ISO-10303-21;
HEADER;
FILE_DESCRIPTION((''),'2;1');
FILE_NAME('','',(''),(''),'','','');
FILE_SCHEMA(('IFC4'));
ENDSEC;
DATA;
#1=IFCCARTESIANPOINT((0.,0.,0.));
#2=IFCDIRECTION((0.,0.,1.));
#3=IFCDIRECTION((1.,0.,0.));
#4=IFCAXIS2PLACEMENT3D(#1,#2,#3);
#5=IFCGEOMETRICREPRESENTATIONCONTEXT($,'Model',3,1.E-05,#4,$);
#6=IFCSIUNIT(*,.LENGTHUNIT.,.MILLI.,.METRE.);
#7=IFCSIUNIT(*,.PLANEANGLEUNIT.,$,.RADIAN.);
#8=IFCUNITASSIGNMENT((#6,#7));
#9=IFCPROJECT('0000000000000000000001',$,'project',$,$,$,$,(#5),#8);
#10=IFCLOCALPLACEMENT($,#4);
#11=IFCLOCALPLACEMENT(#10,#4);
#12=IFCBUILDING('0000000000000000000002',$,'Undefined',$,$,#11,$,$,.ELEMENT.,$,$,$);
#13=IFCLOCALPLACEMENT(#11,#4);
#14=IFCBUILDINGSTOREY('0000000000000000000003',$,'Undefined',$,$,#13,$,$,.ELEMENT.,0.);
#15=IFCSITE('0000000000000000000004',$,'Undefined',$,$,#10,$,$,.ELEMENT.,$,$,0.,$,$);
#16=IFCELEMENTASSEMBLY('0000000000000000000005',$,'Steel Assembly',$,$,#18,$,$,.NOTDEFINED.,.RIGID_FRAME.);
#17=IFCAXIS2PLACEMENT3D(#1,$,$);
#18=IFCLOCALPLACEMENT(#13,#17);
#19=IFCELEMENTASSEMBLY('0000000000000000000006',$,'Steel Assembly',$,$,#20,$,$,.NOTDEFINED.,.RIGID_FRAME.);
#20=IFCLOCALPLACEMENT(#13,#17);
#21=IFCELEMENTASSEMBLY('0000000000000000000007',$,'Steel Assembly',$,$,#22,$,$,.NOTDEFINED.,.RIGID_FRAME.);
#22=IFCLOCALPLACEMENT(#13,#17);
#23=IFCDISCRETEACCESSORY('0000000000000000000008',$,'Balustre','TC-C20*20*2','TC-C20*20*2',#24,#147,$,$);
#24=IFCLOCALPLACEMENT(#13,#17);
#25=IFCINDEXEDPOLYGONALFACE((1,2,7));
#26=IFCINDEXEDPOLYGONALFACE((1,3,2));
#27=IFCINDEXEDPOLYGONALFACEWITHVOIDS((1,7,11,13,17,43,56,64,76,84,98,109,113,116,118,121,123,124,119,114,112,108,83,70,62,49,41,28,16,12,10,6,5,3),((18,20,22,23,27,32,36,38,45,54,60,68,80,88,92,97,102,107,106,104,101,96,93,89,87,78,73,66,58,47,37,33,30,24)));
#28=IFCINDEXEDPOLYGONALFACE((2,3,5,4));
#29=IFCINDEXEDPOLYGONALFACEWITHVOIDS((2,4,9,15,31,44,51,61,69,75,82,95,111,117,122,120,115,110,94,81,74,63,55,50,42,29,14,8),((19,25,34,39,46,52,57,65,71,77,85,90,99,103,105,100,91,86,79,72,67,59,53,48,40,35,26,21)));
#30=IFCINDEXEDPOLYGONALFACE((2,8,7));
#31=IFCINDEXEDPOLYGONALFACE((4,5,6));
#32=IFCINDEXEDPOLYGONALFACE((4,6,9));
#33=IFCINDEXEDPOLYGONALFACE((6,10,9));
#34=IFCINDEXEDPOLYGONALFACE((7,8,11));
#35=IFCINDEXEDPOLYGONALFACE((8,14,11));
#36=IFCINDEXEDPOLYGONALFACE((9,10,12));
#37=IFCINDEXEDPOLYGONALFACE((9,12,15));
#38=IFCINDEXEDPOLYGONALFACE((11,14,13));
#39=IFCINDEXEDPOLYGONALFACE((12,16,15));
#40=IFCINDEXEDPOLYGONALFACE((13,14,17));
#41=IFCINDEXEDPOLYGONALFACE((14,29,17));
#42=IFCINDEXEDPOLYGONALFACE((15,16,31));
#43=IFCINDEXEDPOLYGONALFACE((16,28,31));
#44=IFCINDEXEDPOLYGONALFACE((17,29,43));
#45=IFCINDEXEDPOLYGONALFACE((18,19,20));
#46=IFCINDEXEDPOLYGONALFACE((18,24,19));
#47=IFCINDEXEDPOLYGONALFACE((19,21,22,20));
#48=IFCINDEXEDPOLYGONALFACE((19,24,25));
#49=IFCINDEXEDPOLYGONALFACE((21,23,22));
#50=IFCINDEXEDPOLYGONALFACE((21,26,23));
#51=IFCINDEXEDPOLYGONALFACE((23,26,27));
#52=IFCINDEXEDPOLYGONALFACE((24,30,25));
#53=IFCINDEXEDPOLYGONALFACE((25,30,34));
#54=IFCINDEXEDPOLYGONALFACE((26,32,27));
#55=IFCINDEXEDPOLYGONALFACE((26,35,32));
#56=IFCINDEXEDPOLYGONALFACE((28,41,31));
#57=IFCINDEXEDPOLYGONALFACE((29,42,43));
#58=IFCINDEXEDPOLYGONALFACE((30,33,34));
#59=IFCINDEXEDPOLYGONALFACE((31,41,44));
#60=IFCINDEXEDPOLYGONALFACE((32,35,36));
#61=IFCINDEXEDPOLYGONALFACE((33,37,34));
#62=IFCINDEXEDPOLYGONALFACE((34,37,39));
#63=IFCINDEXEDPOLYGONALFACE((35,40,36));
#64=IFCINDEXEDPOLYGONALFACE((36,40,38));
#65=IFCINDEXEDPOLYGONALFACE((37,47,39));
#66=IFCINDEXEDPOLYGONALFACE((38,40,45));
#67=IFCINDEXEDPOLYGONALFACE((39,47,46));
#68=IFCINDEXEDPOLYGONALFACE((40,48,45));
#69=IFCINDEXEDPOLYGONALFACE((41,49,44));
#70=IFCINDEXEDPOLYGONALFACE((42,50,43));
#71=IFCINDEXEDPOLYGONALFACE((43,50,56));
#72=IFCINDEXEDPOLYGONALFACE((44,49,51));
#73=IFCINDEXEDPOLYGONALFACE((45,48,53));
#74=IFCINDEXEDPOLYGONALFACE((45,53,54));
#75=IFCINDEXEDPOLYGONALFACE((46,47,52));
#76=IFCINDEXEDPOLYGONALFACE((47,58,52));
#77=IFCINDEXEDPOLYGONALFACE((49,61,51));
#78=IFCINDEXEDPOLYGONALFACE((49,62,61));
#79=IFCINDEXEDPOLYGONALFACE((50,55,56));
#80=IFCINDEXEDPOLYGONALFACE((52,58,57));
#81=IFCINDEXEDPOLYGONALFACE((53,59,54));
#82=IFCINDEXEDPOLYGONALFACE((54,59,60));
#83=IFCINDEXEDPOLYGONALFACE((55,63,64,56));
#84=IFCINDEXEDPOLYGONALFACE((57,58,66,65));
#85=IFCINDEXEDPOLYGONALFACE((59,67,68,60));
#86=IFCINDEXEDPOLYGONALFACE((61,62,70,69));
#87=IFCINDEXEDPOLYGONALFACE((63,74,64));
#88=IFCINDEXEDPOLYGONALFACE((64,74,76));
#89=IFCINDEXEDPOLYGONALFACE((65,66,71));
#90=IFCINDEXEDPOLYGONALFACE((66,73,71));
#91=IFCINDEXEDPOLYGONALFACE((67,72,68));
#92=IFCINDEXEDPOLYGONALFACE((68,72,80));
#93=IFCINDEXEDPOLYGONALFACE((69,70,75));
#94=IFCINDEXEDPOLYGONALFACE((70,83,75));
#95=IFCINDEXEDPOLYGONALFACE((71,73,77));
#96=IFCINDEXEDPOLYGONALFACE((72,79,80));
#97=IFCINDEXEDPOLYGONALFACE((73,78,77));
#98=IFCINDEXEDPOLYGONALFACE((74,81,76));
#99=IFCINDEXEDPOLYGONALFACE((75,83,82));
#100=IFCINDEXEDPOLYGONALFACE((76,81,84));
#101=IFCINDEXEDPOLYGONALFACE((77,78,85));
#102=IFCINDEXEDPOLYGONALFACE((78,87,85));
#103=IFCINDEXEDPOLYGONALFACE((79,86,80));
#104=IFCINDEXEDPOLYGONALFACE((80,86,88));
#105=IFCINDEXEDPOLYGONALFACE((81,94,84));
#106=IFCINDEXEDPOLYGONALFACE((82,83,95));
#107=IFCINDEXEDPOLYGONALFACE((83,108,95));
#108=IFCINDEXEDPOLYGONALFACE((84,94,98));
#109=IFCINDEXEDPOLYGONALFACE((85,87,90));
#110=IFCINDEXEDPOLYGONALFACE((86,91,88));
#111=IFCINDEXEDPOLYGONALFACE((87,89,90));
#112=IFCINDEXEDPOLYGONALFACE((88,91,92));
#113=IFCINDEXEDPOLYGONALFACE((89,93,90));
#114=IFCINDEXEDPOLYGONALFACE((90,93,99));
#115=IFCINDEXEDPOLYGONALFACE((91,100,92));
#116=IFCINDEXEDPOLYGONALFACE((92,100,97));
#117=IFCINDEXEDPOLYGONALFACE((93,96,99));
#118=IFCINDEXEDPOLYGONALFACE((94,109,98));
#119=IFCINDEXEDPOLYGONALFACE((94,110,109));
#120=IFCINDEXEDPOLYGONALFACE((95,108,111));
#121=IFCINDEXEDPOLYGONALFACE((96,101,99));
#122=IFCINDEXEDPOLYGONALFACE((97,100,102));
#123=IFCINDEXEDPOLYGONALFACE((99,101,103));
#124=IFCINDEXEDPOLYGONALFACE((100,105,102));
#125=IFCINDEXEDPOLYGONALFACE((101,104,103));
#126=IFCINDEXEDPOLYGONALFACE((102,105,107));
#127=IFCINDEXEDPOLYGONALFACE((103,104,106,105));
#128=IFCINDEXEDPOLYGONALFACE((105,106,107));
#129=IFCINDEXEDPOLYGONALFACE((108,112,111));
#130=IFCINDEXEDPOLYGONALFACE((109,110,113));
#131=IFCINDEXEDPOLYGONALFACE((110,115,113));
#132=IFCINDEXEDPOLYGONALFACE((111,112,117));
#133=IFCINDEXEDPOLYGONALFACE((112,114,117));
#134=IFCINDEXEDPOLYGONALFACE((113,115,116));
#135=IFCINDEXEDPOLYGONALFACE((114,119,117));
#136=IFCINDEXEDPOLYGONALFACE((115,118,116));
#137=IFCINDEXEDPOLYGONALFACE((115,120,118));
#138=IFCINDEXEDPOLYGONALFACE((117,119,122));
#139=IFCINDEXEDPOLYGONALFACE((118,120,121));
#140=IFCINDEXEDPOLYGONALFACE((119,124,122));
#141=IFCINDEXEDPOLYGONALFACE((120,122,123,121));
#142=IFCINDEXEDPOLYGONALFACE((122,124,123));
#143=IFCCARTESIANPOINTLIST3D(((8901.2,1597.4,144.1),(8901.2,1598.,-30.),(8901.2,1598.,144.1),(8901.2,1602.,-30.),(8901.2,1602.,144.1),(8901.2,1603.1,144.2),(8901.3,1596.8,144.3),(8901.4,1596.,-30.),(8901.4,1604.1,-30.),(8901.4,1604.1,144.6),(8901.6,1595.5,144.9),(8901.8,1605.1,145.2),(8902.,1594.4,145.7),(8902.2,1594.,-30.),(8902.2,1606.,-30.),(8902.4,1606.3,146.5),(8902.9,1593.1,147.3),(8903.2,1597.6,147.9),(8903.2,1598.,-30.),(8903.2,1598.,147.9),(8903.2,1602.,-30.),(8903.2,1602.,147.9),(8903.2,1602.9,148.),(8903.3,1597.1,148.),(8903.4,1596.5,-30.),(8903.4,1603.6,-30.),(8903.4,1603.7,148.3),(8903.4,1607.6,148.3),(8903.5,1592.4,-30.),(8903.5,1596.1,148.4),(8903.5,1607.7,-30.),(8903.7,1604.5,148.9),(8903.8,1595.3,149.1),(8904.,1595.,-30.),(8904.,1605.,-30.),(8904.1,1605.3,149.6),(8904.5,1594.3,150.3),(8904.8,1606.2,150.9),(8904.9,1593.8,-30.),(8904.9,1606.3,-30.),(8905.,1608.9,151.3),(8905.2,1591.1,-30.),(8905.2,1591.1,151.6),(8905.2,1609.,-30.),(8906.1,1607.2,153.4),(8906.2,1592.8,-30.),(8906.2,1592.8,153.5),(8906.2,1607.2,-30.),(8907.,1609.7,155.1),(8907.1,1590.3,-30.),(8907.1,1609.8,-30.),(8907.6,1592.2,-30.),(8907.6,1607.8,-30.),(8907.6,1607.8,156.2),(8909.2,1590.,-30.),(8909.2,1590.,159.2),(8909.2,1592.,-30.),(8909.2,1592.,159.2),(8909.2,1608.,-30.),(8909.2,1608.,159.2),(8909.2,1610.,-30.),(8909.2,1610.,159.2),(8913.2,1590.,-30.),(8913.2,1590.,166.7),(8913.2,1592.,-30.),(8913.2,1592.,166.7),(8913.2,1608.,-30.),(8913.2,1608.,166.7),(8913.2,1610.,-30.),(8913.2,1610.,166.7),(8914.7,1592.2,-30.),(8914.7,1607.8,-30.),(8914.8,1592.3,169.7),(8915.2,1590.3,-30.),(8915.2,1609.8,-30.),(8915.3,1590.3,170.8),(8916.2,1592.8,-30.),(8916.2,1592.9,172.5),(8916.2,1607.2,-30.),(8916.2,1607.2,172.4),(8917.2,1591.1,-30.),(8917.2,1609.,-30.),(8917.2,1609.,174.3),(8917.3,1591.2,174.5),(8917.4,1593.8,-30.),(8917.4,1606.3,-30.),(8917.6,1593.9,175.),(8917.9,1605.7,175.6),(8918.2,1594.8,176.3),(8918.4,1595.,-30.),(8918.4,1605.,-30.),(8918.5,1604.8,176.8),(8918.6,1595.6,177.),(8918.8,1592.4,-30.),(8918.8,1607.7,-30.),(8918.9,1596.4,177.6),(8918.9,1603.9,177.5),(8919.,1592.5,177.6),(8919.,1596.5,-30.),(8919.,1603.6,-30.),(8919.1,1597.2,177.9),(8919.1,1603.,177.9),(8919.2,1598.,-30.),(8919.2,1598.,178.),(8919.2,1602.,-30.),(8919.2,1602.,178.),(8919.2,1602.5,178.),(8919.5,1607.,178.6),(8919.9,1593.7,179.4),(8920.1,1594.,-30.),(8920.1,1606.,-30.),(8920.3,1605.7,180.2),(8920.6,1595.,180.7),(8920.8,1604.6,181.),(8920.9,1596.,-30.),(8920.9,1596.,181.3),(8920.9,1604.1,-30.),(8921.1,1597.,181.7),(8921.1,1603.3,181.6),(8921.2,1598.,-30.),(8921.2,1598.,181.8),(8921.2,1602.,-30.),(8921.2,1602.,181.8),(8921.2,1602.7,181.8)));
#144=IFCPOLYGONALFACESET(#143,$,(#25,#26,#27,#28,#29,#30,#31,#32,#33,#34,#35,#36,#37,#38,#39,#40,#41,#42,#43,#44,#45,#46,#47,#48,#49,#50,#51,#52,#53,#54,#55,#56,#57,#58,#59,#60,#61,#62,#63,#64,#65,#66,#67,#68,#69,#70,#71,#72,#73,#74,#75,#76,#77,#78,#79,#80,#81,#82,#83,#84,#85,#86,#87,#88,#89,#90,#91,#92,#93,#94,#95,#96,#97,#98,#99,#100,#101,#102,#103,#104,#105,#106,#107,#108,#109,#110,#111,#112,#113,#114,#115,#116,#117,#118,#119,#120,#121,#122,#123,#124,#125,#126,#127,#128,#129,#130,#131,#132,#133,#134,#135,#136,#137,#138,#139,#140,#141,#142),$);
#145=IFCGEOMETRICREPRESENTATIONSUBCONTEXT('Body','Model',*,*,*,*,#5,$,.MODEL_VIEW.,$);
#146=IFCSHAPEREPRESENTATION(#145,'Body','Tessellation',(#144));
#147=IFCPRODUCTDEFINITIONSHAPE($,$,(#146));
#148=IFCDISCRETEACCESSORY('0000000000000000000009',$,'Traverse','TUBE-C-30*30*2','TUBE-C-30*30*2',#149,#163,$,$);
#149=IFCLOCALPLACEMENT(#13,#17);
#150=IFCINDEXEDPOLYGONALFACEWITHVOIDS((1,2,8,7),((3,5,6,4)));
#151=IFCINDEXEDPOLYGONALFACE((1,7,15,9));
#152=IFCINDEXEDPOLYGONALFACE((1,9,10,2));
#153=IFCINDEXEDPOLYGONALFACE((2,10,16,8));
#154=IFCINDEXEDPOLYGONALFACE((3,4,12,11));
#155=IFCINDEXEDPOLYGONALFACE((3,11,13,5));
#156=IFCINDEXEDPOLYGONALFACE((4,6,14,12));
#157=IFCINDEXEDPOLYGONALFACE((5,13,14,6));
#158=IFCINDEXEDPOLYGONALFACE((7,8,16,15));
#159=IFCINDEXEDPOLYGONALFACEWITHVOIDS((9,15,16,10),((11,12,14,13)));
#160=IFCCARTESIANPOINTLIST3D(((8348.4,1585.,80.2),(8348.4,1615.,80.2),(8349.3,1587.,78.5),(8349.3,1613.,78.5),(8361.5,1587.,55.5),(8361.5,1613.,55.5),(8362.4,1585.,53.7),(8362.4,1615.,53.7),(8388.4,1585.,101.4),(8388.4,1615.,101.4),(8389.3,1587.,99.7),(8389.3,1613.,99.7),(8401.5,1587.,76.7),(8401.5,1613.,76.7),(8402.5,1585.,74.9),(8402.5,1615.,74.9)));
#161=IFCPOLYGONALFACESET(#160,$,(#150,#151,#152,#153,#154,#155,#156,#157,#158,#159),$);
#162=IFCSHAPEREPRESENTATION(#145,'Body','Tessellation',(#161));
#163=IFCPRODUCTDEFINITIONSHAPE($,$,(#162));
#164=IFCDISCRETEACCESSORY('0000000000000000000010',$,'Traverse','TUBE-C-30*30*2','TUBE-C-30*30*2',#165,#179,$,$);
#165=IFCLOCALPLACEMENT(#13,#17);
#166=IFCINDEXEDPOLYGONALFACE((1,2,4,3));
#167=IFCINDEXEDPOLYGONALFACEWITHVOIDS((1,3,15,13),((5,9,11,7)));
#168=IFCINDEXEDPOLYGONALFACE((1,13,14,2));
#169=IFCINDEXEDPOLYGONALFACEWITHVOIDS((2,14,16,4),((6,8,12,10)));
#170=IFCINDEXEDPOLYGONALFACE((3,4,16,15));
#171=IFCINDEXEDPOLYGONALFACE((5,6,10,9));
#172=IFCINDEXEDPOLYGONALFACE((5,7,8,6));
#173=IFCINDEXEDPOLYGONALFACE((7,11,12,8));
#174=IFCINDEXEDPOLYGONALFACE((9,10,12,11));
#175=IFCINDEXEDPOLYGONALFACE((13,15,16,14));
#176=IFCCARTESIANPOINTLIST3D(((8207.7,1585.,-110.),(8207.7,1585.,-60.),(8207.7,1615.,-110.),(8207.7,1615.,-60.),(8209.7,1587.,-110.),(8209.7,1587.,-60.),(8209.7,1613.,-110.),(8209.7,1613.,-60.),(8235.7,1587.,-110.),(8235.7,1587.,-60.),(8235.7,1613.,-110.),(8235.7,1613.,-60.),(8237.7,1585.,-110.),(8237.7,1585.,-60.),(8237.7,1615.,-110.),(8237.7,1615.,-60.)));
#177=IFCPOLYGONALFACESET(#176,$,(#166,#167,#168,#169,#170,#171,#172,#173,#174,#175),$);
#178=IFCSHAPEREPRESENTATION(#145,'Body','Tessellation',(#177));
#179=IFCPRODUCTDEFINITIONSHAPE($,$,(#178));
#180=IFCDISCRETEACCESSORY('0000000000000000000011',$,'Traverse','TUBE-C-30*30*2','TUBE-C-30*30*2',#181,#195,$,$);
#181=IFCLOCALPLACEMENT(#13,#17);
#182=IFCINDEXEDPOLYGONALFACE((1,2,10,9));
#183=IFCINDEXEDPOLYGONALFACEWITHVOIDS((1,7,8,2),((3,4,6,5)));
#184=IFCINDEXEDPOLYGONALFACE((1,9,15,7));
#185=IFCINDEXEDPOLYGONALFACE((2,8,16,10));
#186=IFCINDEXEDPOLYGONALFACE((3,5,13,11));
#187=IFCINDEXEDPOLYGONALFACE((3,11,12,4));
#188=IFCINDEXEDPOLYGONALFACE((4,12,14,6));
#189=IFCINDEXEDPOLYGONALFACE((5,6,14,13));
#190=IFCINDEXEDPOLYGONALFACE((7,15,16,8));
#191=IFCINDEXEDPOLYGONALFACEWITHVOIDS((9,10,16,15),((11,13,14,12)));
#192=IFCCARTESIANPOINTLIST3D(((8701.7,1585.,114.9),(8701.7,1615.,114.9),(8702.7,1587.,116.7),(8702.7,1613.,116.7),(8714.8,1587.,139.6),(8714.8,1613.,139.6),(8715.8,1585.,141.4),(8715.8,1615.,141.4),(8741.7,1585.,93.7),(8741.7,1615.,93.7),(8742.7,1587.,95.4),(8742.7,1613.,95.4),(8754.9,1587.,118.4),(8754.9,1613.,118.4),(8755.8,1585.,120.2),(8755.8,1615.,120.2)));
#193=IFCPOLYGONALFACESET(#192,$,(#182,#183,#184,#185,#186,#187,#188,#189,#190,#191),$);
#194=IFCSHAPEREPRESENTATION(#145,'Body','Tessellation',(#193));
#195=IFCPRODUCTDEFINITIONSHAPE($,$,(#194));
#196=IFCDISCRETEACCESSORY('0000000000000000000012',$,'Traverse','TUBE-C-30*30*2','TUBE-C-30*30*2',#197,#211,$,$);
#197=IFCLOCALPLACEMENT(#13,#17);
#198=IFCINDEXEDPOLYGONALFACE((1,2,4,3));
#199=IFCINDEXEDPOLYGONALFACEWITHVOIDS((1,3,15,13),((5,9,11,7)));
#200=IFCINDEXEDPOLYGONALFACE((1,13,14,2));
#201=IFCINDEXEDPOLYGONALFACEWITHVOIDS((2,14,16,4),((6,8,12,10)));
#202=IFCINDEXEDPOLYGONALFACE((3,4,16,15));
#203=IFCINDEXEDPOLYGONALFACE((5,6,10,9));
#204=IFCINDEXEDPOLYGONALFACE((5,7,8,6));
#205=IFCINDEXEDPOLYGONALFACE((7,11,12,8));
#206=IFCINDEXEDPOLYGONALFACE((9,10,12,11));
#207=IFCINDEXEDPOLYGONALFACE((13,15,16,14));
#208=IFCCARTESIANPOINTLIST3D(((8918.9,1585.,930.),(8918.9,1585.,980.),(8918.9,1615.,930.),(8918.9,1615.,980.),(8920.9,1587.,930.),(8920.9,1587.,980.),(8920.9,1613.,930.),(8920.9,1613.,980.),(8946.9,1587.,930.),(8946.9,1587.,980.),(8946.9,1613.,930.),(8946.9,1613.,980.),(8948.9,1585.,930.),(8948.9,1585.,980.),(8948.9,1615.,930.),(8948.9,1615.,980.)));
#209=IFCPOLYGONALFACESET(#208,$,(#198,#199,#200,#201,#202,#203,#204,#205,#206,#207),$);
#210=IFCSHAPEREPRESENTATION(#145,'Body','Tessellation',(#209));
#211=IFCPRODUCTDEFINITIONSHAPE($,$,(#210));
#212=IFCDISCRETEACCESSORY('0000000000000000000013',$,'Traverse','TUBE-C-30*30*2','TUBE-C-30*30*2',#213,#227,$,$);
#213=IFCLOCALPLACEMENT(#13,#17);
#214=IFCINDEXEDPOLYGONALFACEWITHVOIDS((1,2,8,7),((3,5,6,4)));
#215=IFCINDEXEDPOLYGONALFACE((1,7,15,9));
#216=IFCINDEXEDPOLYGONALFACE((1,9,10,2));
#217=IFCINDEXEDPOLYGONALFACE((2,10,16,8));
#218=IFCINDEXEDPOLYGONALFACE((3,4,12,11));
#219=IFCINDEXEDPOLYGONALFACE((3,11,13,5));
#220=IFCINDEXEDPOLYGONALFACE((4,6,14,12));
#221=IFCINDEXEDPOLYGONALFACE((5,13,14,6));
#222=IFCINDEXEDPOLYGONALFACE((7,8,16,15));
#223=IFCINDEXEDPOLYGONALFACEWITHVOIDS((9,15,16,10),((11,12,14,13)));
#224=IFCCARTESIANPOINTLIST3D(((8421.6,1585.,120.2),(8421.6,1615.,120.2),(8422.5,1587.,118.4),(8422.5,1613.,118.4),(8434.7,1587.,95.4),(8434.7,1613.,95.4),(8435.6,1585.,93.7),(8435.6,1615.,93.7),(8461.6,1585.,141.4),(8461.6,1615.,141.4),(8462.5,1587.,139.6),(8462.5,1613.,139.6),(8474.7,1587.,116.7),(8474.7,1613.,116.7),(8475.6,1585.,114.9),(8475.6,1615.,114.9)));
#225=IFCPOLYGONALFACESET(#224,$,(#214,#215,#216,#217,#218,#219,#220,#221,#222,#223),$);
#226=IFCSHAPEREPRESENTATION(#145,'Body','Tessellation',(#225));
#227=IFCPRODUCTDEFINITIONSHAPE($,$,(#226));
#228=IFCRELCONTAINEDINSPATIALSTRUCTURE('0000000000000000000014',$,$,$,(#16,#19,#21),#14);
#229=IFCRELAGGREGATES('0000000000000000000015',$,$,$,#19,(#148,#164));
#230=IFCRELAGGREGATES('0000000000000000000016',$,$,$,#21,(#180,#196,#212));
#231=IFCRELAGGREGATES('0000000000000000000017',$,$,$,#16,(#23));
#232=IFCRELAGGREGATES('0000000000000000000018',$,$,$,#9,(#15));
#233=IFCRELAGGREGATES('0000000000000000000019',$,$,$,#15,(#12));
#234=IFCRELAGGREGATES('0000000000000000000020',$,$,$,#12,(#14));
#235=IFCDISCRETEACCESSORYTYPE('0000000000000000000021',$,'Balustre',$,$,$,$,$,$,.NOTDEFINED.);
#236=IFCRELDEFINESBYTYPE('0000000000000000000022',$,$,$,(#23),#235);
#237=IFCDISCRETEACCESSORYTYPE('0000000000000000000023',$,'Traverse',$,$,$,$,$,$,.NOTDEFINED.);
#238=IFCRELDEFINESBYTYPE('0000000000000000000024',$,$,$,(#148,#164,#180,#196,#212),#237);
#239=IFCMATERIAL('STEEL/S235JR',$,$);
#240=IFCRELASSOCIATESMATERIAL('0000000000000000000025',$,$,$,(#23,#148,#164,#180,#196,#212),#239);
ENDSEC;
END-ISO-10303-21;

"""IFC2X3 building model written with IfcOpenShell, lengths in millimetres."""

from ifc_helpers import new_model, si_unit, frame, origin_with_axes, origin_2d_with_axis, place, context, subcontext, project, spatial, hollow_rectangle, extrude, clip, halfspace, material, type_object, element, aggregate, save


model = new_model("IFC2X3")

# Units and contexts
model_context = context("Model", 3, precision=1e-05, world=origin_with_axes())
body_context = subcontext(model_context, "Body", "Model", "MODEL_VIEW")
ifc_project = project(units=[si_unit("LENGTHUNIT", "METRE", prefix="MILLI"), si_unit("PLANEANGLEUNIT", "RADIAN")], contexts=[model_context])

# Site, building, storey
site_placement = place(None, origin_with_axes())
site = spatial("IfcSite", under=ifc_project, at=site_placement, Name="Undefined", CompositionType="ELEMENT", RefElevation=0.0)
building_placement = place(site_placement, origin_with_axes())
building = spatial("IfcBuilding", under=site, at=building_placement, Name="Undefined", CompositionType="ELEMENT")
storey_placement = place(building_placement, origin_with_axes())
storey = spatial("IfcBuildingStorey", under=building, at=storey_placement, Name="Undefined", CompositionType="ELEMENT", Elevation=0.0)

# Element assembly
assembly_1_placement = place(storey_placement, origin_with_axes())
assembly_1 = element("IfcElementAssembly", 1, at=assembly_1_placement, inside=storey, Name="Steel Assembly", AssemblyPlace="NOTDEFINED", PredefinedType="RIGID_FRAME")
ifc_material = material(Name="STEEL/S235JR")

# Element assemblies
assembly_2_placement = place(storey_placement, origin_with_axes())
assembly_2 = element("IfcElementAssembly", 2, at=assembly_2_placement, inside=storey, Name="Steel Assembly", AssemblyPlace="NOTDEFINED", PredefinedType="RIGID_FRAME")
discrete_accessory_type_1 = type_object("IfcDiscreteAccessoryType", Name="Balustre")
assembly_3_placement = place(storey_placement, origin_with_axes())
assembly_3 = element("IfcElementAssembly", 3, at=assembly_3_placement, inside=storey, Name="Steel Assembly", AssemblyPlace="NOTDEFINED", PredefinedType="RIGID_FRAME")

# Discrete accessories
discrete_accessory_1_placement = place(assembly_1_placement, frame((8911.2, 1600.0, -30.0), z_axis=(0.0, 0.0, 1.0), x_axis=(1.0, 0.0, 0.0)))
discrete_accessory_1 = element("IfcDiscreteAccessory", 4, at=discrete_accessory_1_placement, type_object=discrete_accessory_type_1, material=ifc_material, Name="Balustre", Description="TC-C20*20*2", ObjectType="TC-C20*20*2", context=body_context, shape_type="Clipping", body=[
    clip(extrude(hollow_rectangle(XDim=20.0, YDim=20.0, WallThickness=2.0, InnerFilletRadius=6.0, OuterFilletRadius=8.0, at=origin_2d_with_axis()), frame((0.0, 0.0, 212.0), z_axis=(0.0, 0.0, -1.0), x_axis=(-1.0, 0.0, 0.0)), (0.0, 0.0, 1.0), 212.0), halfspace(frame((15.1, 0.0, 221.5), z_axis=(0.883506, 0.000005, -0.46842), x_axis=(-0.000005, 1.0, 0.0)), True)),
])
discrete_accessory_type_2 = type_object("IfcDiscreteAccessoryType", Name="Traverse")
discrete_accessory_2_placement = place(assembly_2_placement, frame((8355.4, 1600.0, 67.0), z_axis=(-0.000011, 1.0, 0.0), x_axis=(0.883506, 0.00001, 0.46842)))
discrete_accessory_2 = element("IfcDiscreteAccessory", 5, at=discrete_accessory_2_placement, type_object=discrete_accessory_type_2, material=ifc_material, Name="Traverse", Description="TUBE-C-30*30*2", ObjectType="TUBE-C-30*30*2", context=body_context, shape_type="SweptSolid", body=[
    extrude(hollow_rectangle(XDim=30.0, YDim=30.0, WallThickness=2.0, at=origin_2d_with_axis()), frame((45.3, 0.0, 0.0), z_axis=(-1.0, 0.0, 0.0), x_axis=(0.0, -1.0, 0.0)), (0.0, 0.0, 1.0), 45.3),
])
discrete_accessory_3_placement = place(assembly_2_placement, frame((8222.7, 1600.0, -60.0), z_axis=(-0.000011, 1.0, 0.0), x_axis=(0.0, 0.0, -1.0)))
discrete_accessory_3 = element("IfcDiscreteAccessory", 6, at=discrete_accessory_3_placement, type_object=discrete_accessory_type_2, material=ifc_material, Name="Traverse", Description="TUBE-C-30*30*2", ObjectType="TUBE-C-30*30*2", context=body_context, shape_type="SweptSolid", body=[
    extrude(hollow_rectangle(XDim=30.0, YDim=30.0, WallThickness=2.0, at=origin_2d_with_axis()), frame((50.0, 0.0, 0.0), z_axis=(-1.0, 0.0, 0.0), x_axis=(0.0, -1.0, 0.0)), (0.0, 0.0, 1.0), 50.0),
])
aggregate(assembly_2, [discrete_accessory_2, discrete_accessory_3])
discrete_accessory_4_placement = place(assembly_3_placement, frame((8708.7, 1600.0, 128.2), z_axis=(0.0, 1.0, 0.0), x_axis=(0.883506, 0.0, -0.46842)))
discrete_accessory_4 = element("IfcDiscreteAccessory", 7, at=discrete_accessory_4_placement, type_object=discrete_accessory_type_2, material=ifc_material, Name="Traverse", Description="TUBE-C-30*30*2", ObjectType="TUBE-C-30*30*2", context=body_context, shape_type="SweptSolid", body=[
    extrude(hollow_rectangle(XDim=30.0, YDim=30.0, WallThickness=2.0, at=origin_2d_with_axis()), frame((45.3, 0.0, 0.0), z_axis=(-1.0, 0.0, 0.0), x_axis=(0.0, -1.0, 0.0)), (0.0, 0.0, 1.0), 45.3),
])
discrete_accessory_5_placement = place(assembly_3_placement, frame((8933.9, 1600.0, 930.0), z_axis=(0.0, 0.0, 1.0), x_axis=(1.0, 0.0, 0.0)))
discrete_accessory_5 = element("IfcDiscreteAccessory", 8, at=discrete_accessory_5_placement, type_object=discrete_accessory_type_2, material=ifc_material, Name="Traverse", Description="TUBE-C-30*30*2", ObjectType="TUBE-C-30*30*2", context=body_context, shape_type="SweptSolid", body=[
    extrude(hollow_rectangle(XDim=30.0, YDim=30.0, WallThickness=2.0, at=origin_2d_with_axis()), frame((0.0, 0.0, 50.0), z_axis=(0.0, 0.0, -1.0), x_axis=(-1.0, 0.0, 0.0)), (0.0, 0.0, 1.0), 50.0),
])
discrete_accessory_6_placement = place(assembly_3_placement, frame((8468.6, 1600.0, 128.2), z_axis=(0.0, 1.0, 0.0), x_axis=(-0.883506, 0.0, -0.46842)))
discrete_accessory_6 = element("IfcDiscreteAccessory", 9, at=discrete_accessory_6_placement, type_object=discrete_accessory_type_2, material=ifc_material, Name="Traverse", Description="TUBE-C-30*30*2", ObjectType="TUBE-C-30*30*2", context=body_context, shape_type="SweptSolid", body=[
    extrude(hollow_rectangle(XDim=30.0, YDim=30.0, WallThickness=2.0, at=origin_2d_with_axis()), frame((45.3, 0.0, 0.0), z_axis=(-1.0, 0.0, 0.0), x_axis=(0.0, -1.0, 0.0)), (0.0, 0.0, 1.0), 45.3),
])
aggregate(assembly_3, [discrete_accessory_4, discrete_accessory_5, discrete_accessory_6])
aggregate(assembly_1, [discrete_accessory_1])

save(model, "model.ifc")
